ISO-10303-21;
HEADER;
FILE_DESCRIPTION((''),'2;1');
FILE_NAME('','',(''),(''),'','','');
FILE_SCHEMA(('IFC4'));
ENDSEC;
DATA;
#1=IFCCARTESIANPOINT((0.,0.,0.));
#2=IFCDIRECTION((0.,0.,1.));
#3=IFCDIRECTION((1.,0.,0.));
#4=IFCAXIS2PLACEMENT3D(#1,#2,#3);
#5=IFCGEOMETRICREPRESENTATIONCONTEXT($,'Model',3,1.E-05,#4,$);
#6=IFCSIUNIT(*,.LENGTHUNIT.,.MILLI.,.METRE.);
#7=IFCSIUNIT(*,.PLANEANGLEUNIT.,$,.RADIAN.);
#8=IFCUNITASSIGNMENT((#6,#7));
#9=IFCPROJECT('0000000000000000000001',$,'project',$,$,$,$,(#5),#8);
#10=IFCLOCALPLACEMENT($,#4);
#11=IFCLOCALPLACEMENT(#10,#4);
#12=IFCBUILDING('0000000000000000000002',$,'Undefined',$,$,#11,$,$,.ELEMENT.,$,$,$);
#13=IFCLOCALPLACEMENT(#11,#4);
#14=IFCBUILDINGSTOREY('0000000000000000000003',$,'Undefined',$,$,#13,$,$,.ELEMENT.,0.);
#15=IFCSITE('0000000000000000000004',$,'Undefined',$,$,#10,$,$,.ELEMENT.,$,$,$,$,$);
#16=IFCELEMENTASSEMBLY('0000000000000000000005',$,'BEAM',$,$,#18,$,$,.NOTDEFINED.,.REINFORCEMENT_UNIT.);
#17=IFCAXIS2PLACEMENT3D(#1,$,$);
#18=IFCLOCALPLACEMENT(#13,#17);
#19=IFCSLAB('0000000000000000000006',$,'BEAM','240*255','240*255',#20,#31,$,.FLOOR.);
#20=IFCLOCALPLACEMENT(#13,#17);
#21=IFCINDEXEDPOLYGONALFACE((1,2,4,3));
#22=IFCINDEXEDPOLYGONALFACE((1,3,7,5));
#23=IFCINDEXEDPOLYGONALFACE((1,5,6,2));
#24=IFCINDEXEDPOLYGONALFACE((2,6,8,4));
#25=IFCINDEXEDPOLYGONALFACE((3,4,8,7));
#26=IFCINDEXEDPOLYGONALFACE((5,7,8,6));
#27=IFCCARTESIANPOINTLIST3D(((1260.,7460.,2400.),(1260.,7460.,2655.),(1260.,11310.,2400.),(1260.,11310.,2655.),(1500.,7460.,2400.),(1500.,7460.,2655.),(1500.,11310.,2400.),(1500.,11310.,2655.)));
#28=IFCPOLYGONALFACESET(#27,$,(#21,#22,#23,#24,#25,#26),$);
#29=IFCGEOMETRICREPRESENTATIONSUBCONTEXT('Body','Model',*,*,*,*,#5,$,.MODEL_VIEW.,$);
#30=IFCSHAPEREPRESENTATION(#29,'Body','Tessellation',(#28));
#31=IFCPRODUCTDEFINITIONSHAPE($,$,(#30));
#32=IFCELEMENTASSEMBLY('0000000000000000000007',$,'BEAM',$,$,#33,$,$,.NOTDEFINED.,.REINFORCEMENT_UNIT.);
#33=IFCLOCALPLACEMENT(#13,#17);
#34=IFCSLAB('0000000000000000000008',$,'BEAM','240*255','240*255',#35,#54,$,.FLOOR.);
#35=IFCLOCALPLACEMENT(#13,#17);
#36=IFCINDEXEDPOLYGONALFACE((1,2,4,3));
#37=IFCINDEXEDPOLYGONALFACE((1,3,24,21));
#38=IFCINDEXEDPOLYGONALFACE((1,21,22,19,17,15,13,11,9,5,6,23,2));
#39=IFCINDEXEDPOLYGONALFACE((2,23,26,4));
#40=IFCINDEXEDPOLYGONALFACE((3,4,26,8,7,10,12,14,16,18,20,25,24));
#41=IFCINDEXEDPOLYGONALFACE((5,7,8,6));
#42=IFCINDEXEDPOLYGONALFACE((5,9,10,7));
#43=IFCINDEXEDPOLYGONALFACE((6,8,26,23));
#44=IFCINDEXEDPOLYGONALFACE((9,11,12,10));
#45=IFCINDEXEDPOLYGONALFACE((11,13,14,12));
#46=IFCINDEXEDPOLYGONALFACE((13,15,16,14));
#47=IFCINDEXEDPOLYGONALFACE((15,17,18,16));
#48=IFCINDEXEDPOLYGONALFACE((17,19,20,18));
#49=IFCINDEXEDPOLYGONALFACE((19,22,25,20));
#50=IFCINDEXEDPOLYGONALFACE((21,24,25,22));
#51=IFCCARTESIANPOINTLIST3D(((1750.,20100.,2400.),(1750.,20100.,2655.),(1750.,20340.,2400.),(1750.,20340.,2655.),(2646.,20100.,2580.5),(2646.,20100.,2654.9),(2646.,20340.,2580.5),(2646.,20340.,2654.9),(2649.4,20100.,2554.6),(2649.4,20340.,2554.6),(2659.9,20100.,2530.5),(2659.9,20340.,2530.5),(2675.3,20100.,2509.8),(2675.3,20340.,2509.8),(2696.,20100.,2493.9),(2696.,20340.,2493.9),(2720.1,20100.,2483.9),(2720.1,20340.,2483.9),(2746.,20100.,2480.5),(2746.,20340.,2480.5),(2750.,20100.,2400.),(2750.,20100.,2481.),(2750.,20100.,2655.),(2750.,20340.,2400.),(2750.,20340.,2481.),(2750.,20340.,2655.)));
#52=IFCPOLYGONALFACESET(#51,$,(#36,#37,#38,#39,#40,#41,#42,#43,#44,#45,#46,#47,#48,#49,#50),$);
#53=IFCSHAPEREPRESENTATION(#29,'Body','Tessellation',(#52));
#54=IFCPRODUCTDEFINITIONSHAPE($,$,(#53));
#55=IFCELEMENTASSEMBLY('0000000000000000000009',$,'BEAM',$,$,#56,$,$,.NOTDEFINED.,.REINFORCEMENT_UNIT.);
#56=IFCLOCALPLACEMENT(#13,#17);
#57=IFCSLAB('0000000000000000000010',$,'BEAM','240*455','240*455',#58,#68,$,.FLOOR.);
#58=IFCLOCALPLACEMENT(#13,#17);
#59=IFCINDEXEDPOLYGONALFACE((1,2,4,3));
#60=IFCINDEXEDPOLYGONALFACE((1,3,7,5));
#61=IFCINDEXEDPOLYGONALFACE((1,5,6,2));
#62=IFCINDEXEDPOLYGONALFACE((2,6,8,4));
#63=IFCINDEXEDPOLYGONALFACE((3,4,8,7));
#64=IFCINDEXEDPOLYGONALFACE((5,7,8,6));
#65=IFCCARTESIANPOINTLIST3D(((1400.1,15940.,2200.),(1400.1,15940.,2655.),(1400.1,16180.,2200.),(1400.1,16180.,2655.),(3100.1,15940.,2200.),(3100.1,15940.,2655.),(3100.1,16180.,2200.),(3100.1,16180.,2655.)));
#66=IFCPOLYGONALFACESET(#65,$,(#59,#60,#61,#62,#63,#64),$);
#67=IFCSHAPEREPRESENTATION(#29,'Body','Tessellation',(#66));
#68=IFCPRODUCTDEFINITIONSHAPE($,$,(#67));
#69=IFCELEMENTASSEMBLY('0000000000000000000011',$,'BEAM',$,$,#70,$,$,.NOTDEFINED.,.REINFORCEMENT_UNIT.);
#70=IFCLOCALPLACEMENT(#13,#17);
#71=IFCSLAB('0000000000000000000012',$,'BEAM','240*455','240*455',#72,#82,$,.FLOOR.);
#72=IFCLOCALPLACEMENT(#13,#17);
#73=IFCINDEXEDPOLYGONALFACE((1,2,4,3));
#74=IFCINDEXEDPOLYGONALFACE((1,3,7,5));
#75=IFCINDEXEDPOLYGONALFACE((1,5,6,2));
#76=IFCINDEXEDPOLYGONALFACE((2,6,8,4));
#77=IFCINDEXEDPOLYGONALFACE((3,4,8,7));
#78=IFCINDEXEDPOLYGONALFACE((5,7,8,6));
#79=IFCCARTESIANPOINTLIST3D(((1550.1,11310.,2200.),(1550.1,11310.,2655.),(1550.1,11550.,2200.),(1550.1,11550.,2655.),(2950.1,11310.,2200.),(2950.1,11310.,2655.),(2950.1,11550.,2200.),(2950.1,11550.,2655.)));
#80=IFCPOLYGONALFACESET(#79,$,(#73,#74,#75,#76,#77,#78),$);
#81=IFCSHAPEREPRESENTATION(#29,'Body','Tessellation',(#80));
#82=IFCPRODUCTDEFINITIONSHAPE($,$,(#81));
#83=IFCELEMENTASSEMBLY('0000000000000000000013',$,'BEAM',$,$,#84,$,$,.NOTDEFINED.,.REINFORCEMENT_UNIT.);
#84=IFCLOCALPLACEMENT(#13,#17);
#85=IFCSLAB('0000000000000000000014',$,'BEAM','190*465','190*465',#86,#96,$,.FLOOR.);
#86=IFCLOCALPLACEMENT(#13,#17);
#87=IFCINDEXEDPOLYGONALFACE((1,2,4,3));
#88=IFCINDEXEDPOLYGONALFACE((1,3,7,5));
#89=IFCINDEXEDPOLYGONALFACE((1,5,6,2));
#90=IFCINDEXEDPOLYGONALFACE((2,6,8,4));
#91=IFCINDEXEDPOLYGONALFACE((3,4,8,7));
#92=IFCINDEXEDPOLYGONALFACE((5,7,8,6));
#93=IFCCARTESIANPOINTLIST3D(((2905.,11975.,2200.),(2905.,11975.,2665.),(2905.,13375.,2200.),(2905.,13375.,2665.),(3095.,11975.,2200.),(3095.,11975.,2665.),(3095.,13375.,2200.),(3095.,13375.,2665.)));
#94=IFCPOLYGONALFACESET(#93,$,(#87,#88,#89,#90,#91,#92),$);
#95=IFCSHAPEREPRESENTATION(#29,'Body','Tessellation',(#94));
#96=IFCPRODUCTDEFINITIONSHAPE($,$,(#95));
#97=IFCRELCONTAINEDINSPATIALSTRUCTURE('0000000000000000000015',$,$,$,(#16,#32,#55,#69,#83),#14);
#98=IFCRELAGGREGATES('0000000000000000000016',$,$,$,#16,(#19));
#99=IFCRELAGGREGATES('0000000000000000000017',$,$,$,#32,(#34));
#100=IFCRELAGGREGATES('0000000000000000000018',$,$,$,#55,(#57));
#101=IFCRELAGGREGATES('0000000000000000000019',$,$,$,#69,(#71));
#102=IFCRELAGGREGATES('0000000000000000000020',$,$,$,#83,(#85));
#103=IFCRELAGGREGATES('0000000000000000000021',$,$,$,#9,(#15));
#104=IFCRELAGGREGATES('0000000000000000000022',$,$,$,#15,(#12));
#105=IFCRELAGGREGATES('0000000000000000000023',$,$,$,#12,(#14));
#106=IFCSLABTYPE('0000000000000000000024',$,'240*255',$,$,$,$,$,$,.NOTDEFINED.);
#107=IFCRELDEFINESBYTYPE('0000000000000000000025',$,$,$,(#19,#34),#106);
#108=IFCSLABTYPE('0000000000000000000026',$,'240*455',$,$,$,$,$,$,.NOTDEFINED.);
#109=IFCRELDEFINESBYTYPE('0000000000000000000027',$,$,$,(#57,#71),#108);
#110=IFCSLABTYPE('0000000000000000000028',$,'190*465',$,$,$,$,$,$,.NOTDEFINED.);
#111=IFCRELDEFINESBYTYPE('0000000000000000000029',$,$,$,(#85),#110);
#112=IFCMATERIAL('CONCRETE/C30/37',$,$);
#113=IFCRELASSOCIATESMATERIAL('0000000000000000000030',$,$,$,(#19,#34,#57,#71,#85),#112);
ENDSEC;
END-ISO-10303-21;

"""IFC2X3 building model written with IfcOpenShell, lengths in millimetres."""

from ifc_helpers import new_model, si_unit, frame, origin_with_axes, place, context, subcontext, project, spatial, polyline, outline, extrude, boolean, material, type_object, element, aggregate, save


model = new_model("IFC2X3")

# Units and contexts
model_context = context("Model", 3, precision=1e-05, world=origin_with_axes())
body_context = subcontext(model_context, "Body", "Model", "MODEL_VIEW")
ifc_project = project(units=[si_unit("LENGTHUNIT", "METRE", prefix="MILLI"), si_unit("PLANEANGLEUNIT", "RADIAN")], contexts=[model_context])

# Site, building, storey
site_placement = place(None, origin_with_axes())
site = spatial("IfcSite", under=ifc_project, at=site_placement, Name="Undefined", CompositionType="ELEMENT")
building_placement = place(site_placement, origin_with_axes())
building = spatial("IfcBuilding", under=site, at=building_placement, Name="Undefined", CompositionType="ELEMENT")
storey_placement = place(building_placement, origin_with_axes())
storey = spatial("IfcBuildingStorey", under=building, at=storey_placement, Name="Undefined", CompositionType="ELEMENT", Elevation=0.0)

# Element assemblies, slabs
assembly_1_placement = place(storey_placement, origin_with_axes())
assembly_1 = element("IfcElementAssembly", 1, at=assembly_1_placement, inside=storey, Name="BEAM", AssemblyPlace="NOTDEFINED", PredefinedType="REINFORCEMENT_UNIT")
ifc_material_1 = material(Name="CONCRETE/C30/37")
slab_type_1 = type_object("IfcSlabType", Name="240*255", PredefinedType="NOTDEFINED")
slab_1_placement = place(assembly_1_placement, frame((1380.0, 11310.0, 2400.0), z_axis=(1.0, 0.0, 0.0), x_axis=(0.0, 0.0, 1.0)))
slab_1 = element("IfcSlab", 2, at=slab_1_placement, type_object=slab_type_1, material=ifc_material_1, Name="BEAM", Description="240*255", ObjectType="240*255", PredefinedType="FLOOR", context=body_context, shape_type="SweptSolid", body=[
    extrude(outline(polyline([(0.0, 0.0), (255.0, 0.0), (255.0, 3850.0), (0.0, 3850.0), (0.0, 0.0)])), frame((0.0, 0.0, -120.0), z_axis=(0.0, 0.0, 1.0), x_axis=(1.0, 0.0, 0.0)), (0.0, 0.0, 1.0), 240.0),
])
aggregate(assembly_1, [slab_1])
assembly_2_placement = place(storey_placement, origin_with_axes())
assembly_2 = element("IfcElementAssembly", 3, at=assembly_2_placement, inside=storey, Name="BEAM", AssemblyPlace="NOTDEFINED", PredefinedType="REINFORCEMENT_UNIT")
slab_2_placement = place(assembly_2_placement, frame((2750.0, 20220.0, 2400.0), z_axis=(0.0, -1.0, 0.0), x_axis=(0.0, 0.0, 1.0)))
slab_2 = element("IfcSlab", 4, at=slab_2_placement, type_object=slab_type_1, material=ifc_material_1, Name="BEAM", Description="240*255", ObjectType="240*255", PredefinedType="FLOOR", context=body_context, shape_type="CSG", body=[
    boolean("DIFFERENCE", extrude(outline(polyline([(0.0, 0.0), (255.0, 0.0), (255.0, 1000.0), (0.0, 1000.0), (0.0, 0.0)])), frame((0.0, 0.0, -120.0), z_axis=(0.0, 0.0, 1.0), x_axis=(1.0, 0.0, 0.0)), (0.0, 0.0, 1.0), 240.0), extrude(outline(polyline([(0.0, 0.0), (174.0, 0.0), (174.5, 4.0), (171.1, 29.9), (161.1, 54.0), (145.2, 74.7), (124.5, 90.1), (100.4, 100.6), (74.5, 104.0), (0.1, 104.0), (0.0, 0.0)])), frame((255.0, 0.0, 125.0), z_axis=(0.000017, -0.000029, -1.0), x_axis=(-1.0, 0.000002, -0.000017)), (0.0, 0.0, 1.0), 250.0)),
])
assembly_3_placement = place(storey_placement, origin_with_axes())
assembly_3 = element("IfcElementAssembly", 5, at=assembly_3_placement, inside=storey, Name="BEAM", AssemblyPlace="NOTDEFINED", PredefinedType="REINFORCEMENT_UNIT")
slab_type_2 = type_object("IfcSlabType", Name="240*455", PredefinedType="NOTDEFINED")
slab_3_placement = place(assembly_3_placement, frame((1400.1, 16060.0, 2200.0), z_axis=(0.0, 1.0, 0.0), x_axis=(0.0, 0.0, 1.0)))
slab_3 = element("IfcSlab", 6, at=slab_3_placement, type_object=slab_type_2, material=ifc_material_1, Name="BEAM", Description="240*455", ObjectType="240*455", PredefinedType="FLOOR", context=body_context, shape_type="SweptSolid", body=[
    extrude(outline(polyline([(0.0, 0.0), (455.0, 0.0), (455.0, 1700.0), (0.0, 1700.0), (0.0, 0.0)])), frame((0.0, 0.0, -120.0), z_axis=(0.0, 0.0, 1.0), x_axis=(1.0, 0.0, 0.0)), (0.0, 0.0, 1.0), 240.0),
])
assembly_4_placement = place(storey_placement, origin_with_axes())
assembly_4 = element("IfcElementAssembly", 7, at=assembly_4_placement, inside=storey, Name="BEAM", AssemblyPlace="NOTDEFINED", PredefinedType="REINFORCEMENT_UNIT")
slab_4_placement = place(assembly_4_placement, frame((1550.1, 11430.0, 2200.0), z_axis=(0.0, 1.0, 0.0), x_axis=(0.0, 0.0, 1.0)))
slab_4 = element("IfcSlab", 8, at=slab_4_placement, type_object=slab_type_2, material=ifc_material_1, Name="BEAM", Description="240*455", ObjectType="240*455", PredefinedType="FLOOR", context=body_context, shape_type="SweptSolid", body=[
    extrude(outline(polyline([(0.0, 0.0), (455.0, 0.0), (455.0, 1400.0), (0.0, 1400.0), (0.0, 0.0)])), frame((0.0, 0.0, -120.0), z_axis=(0.0, 0.0, 1.0), x_axis=(1.0, 0.0, 0.0)), (0.0, 0.0, 1.0), 240.0),
])
assembly_5_placement = place(storey_placement, origin_with_axes())
assembly_5 = element("IfcElementAssembly", 9, at=assembly_5_placement, inside=storey, Name="BEAM", AssemblyPlace="NOTDEFINED", PredefinedType="REINFORCEMENT_UNIT")
slab_type_3 = type_object("IfcSlabType", Name="190*465", PredefinedType="NOTDEFINED")
slab_5_placement = place(assembly_5_placement, frame((3000.0, 13375.0, 2200.0), z_axis=(1.0, 0.0, 0.0), x_axis=(0.0, 0.0, 1.0)))
slab_5 = element("IfcSlab", 10, at=slab_5_placement, type_object=slab_type_3, material=ifc_material_1, Name="BEAM", Description="190*465", ObjectType="190*465", PredefinedType="FLOOR", context=body_context, shape_type="SweptSolid", body=[
    extrude(outline(polyline([(0.0, 0.0), (465.0, 0.0), (465.0, 1400.0), (0.0, 1400.0), (0.0, 0.0)])), frame((0.0, 0.0, -95.0), z_axis=(0.0, 0.0, 1.0), x_axis=(1.0, 0.0, 0.0)), (0.0, 0.0, 1.0), 190.0),
])

aggregate(assembly_2, [slab_2])
aggregate(assembly_3, [slab_3])
aggregate(assembly_4, [slab_4])
aggregate(assembly_5, [slab_5])

save(model, "model.ifc")
